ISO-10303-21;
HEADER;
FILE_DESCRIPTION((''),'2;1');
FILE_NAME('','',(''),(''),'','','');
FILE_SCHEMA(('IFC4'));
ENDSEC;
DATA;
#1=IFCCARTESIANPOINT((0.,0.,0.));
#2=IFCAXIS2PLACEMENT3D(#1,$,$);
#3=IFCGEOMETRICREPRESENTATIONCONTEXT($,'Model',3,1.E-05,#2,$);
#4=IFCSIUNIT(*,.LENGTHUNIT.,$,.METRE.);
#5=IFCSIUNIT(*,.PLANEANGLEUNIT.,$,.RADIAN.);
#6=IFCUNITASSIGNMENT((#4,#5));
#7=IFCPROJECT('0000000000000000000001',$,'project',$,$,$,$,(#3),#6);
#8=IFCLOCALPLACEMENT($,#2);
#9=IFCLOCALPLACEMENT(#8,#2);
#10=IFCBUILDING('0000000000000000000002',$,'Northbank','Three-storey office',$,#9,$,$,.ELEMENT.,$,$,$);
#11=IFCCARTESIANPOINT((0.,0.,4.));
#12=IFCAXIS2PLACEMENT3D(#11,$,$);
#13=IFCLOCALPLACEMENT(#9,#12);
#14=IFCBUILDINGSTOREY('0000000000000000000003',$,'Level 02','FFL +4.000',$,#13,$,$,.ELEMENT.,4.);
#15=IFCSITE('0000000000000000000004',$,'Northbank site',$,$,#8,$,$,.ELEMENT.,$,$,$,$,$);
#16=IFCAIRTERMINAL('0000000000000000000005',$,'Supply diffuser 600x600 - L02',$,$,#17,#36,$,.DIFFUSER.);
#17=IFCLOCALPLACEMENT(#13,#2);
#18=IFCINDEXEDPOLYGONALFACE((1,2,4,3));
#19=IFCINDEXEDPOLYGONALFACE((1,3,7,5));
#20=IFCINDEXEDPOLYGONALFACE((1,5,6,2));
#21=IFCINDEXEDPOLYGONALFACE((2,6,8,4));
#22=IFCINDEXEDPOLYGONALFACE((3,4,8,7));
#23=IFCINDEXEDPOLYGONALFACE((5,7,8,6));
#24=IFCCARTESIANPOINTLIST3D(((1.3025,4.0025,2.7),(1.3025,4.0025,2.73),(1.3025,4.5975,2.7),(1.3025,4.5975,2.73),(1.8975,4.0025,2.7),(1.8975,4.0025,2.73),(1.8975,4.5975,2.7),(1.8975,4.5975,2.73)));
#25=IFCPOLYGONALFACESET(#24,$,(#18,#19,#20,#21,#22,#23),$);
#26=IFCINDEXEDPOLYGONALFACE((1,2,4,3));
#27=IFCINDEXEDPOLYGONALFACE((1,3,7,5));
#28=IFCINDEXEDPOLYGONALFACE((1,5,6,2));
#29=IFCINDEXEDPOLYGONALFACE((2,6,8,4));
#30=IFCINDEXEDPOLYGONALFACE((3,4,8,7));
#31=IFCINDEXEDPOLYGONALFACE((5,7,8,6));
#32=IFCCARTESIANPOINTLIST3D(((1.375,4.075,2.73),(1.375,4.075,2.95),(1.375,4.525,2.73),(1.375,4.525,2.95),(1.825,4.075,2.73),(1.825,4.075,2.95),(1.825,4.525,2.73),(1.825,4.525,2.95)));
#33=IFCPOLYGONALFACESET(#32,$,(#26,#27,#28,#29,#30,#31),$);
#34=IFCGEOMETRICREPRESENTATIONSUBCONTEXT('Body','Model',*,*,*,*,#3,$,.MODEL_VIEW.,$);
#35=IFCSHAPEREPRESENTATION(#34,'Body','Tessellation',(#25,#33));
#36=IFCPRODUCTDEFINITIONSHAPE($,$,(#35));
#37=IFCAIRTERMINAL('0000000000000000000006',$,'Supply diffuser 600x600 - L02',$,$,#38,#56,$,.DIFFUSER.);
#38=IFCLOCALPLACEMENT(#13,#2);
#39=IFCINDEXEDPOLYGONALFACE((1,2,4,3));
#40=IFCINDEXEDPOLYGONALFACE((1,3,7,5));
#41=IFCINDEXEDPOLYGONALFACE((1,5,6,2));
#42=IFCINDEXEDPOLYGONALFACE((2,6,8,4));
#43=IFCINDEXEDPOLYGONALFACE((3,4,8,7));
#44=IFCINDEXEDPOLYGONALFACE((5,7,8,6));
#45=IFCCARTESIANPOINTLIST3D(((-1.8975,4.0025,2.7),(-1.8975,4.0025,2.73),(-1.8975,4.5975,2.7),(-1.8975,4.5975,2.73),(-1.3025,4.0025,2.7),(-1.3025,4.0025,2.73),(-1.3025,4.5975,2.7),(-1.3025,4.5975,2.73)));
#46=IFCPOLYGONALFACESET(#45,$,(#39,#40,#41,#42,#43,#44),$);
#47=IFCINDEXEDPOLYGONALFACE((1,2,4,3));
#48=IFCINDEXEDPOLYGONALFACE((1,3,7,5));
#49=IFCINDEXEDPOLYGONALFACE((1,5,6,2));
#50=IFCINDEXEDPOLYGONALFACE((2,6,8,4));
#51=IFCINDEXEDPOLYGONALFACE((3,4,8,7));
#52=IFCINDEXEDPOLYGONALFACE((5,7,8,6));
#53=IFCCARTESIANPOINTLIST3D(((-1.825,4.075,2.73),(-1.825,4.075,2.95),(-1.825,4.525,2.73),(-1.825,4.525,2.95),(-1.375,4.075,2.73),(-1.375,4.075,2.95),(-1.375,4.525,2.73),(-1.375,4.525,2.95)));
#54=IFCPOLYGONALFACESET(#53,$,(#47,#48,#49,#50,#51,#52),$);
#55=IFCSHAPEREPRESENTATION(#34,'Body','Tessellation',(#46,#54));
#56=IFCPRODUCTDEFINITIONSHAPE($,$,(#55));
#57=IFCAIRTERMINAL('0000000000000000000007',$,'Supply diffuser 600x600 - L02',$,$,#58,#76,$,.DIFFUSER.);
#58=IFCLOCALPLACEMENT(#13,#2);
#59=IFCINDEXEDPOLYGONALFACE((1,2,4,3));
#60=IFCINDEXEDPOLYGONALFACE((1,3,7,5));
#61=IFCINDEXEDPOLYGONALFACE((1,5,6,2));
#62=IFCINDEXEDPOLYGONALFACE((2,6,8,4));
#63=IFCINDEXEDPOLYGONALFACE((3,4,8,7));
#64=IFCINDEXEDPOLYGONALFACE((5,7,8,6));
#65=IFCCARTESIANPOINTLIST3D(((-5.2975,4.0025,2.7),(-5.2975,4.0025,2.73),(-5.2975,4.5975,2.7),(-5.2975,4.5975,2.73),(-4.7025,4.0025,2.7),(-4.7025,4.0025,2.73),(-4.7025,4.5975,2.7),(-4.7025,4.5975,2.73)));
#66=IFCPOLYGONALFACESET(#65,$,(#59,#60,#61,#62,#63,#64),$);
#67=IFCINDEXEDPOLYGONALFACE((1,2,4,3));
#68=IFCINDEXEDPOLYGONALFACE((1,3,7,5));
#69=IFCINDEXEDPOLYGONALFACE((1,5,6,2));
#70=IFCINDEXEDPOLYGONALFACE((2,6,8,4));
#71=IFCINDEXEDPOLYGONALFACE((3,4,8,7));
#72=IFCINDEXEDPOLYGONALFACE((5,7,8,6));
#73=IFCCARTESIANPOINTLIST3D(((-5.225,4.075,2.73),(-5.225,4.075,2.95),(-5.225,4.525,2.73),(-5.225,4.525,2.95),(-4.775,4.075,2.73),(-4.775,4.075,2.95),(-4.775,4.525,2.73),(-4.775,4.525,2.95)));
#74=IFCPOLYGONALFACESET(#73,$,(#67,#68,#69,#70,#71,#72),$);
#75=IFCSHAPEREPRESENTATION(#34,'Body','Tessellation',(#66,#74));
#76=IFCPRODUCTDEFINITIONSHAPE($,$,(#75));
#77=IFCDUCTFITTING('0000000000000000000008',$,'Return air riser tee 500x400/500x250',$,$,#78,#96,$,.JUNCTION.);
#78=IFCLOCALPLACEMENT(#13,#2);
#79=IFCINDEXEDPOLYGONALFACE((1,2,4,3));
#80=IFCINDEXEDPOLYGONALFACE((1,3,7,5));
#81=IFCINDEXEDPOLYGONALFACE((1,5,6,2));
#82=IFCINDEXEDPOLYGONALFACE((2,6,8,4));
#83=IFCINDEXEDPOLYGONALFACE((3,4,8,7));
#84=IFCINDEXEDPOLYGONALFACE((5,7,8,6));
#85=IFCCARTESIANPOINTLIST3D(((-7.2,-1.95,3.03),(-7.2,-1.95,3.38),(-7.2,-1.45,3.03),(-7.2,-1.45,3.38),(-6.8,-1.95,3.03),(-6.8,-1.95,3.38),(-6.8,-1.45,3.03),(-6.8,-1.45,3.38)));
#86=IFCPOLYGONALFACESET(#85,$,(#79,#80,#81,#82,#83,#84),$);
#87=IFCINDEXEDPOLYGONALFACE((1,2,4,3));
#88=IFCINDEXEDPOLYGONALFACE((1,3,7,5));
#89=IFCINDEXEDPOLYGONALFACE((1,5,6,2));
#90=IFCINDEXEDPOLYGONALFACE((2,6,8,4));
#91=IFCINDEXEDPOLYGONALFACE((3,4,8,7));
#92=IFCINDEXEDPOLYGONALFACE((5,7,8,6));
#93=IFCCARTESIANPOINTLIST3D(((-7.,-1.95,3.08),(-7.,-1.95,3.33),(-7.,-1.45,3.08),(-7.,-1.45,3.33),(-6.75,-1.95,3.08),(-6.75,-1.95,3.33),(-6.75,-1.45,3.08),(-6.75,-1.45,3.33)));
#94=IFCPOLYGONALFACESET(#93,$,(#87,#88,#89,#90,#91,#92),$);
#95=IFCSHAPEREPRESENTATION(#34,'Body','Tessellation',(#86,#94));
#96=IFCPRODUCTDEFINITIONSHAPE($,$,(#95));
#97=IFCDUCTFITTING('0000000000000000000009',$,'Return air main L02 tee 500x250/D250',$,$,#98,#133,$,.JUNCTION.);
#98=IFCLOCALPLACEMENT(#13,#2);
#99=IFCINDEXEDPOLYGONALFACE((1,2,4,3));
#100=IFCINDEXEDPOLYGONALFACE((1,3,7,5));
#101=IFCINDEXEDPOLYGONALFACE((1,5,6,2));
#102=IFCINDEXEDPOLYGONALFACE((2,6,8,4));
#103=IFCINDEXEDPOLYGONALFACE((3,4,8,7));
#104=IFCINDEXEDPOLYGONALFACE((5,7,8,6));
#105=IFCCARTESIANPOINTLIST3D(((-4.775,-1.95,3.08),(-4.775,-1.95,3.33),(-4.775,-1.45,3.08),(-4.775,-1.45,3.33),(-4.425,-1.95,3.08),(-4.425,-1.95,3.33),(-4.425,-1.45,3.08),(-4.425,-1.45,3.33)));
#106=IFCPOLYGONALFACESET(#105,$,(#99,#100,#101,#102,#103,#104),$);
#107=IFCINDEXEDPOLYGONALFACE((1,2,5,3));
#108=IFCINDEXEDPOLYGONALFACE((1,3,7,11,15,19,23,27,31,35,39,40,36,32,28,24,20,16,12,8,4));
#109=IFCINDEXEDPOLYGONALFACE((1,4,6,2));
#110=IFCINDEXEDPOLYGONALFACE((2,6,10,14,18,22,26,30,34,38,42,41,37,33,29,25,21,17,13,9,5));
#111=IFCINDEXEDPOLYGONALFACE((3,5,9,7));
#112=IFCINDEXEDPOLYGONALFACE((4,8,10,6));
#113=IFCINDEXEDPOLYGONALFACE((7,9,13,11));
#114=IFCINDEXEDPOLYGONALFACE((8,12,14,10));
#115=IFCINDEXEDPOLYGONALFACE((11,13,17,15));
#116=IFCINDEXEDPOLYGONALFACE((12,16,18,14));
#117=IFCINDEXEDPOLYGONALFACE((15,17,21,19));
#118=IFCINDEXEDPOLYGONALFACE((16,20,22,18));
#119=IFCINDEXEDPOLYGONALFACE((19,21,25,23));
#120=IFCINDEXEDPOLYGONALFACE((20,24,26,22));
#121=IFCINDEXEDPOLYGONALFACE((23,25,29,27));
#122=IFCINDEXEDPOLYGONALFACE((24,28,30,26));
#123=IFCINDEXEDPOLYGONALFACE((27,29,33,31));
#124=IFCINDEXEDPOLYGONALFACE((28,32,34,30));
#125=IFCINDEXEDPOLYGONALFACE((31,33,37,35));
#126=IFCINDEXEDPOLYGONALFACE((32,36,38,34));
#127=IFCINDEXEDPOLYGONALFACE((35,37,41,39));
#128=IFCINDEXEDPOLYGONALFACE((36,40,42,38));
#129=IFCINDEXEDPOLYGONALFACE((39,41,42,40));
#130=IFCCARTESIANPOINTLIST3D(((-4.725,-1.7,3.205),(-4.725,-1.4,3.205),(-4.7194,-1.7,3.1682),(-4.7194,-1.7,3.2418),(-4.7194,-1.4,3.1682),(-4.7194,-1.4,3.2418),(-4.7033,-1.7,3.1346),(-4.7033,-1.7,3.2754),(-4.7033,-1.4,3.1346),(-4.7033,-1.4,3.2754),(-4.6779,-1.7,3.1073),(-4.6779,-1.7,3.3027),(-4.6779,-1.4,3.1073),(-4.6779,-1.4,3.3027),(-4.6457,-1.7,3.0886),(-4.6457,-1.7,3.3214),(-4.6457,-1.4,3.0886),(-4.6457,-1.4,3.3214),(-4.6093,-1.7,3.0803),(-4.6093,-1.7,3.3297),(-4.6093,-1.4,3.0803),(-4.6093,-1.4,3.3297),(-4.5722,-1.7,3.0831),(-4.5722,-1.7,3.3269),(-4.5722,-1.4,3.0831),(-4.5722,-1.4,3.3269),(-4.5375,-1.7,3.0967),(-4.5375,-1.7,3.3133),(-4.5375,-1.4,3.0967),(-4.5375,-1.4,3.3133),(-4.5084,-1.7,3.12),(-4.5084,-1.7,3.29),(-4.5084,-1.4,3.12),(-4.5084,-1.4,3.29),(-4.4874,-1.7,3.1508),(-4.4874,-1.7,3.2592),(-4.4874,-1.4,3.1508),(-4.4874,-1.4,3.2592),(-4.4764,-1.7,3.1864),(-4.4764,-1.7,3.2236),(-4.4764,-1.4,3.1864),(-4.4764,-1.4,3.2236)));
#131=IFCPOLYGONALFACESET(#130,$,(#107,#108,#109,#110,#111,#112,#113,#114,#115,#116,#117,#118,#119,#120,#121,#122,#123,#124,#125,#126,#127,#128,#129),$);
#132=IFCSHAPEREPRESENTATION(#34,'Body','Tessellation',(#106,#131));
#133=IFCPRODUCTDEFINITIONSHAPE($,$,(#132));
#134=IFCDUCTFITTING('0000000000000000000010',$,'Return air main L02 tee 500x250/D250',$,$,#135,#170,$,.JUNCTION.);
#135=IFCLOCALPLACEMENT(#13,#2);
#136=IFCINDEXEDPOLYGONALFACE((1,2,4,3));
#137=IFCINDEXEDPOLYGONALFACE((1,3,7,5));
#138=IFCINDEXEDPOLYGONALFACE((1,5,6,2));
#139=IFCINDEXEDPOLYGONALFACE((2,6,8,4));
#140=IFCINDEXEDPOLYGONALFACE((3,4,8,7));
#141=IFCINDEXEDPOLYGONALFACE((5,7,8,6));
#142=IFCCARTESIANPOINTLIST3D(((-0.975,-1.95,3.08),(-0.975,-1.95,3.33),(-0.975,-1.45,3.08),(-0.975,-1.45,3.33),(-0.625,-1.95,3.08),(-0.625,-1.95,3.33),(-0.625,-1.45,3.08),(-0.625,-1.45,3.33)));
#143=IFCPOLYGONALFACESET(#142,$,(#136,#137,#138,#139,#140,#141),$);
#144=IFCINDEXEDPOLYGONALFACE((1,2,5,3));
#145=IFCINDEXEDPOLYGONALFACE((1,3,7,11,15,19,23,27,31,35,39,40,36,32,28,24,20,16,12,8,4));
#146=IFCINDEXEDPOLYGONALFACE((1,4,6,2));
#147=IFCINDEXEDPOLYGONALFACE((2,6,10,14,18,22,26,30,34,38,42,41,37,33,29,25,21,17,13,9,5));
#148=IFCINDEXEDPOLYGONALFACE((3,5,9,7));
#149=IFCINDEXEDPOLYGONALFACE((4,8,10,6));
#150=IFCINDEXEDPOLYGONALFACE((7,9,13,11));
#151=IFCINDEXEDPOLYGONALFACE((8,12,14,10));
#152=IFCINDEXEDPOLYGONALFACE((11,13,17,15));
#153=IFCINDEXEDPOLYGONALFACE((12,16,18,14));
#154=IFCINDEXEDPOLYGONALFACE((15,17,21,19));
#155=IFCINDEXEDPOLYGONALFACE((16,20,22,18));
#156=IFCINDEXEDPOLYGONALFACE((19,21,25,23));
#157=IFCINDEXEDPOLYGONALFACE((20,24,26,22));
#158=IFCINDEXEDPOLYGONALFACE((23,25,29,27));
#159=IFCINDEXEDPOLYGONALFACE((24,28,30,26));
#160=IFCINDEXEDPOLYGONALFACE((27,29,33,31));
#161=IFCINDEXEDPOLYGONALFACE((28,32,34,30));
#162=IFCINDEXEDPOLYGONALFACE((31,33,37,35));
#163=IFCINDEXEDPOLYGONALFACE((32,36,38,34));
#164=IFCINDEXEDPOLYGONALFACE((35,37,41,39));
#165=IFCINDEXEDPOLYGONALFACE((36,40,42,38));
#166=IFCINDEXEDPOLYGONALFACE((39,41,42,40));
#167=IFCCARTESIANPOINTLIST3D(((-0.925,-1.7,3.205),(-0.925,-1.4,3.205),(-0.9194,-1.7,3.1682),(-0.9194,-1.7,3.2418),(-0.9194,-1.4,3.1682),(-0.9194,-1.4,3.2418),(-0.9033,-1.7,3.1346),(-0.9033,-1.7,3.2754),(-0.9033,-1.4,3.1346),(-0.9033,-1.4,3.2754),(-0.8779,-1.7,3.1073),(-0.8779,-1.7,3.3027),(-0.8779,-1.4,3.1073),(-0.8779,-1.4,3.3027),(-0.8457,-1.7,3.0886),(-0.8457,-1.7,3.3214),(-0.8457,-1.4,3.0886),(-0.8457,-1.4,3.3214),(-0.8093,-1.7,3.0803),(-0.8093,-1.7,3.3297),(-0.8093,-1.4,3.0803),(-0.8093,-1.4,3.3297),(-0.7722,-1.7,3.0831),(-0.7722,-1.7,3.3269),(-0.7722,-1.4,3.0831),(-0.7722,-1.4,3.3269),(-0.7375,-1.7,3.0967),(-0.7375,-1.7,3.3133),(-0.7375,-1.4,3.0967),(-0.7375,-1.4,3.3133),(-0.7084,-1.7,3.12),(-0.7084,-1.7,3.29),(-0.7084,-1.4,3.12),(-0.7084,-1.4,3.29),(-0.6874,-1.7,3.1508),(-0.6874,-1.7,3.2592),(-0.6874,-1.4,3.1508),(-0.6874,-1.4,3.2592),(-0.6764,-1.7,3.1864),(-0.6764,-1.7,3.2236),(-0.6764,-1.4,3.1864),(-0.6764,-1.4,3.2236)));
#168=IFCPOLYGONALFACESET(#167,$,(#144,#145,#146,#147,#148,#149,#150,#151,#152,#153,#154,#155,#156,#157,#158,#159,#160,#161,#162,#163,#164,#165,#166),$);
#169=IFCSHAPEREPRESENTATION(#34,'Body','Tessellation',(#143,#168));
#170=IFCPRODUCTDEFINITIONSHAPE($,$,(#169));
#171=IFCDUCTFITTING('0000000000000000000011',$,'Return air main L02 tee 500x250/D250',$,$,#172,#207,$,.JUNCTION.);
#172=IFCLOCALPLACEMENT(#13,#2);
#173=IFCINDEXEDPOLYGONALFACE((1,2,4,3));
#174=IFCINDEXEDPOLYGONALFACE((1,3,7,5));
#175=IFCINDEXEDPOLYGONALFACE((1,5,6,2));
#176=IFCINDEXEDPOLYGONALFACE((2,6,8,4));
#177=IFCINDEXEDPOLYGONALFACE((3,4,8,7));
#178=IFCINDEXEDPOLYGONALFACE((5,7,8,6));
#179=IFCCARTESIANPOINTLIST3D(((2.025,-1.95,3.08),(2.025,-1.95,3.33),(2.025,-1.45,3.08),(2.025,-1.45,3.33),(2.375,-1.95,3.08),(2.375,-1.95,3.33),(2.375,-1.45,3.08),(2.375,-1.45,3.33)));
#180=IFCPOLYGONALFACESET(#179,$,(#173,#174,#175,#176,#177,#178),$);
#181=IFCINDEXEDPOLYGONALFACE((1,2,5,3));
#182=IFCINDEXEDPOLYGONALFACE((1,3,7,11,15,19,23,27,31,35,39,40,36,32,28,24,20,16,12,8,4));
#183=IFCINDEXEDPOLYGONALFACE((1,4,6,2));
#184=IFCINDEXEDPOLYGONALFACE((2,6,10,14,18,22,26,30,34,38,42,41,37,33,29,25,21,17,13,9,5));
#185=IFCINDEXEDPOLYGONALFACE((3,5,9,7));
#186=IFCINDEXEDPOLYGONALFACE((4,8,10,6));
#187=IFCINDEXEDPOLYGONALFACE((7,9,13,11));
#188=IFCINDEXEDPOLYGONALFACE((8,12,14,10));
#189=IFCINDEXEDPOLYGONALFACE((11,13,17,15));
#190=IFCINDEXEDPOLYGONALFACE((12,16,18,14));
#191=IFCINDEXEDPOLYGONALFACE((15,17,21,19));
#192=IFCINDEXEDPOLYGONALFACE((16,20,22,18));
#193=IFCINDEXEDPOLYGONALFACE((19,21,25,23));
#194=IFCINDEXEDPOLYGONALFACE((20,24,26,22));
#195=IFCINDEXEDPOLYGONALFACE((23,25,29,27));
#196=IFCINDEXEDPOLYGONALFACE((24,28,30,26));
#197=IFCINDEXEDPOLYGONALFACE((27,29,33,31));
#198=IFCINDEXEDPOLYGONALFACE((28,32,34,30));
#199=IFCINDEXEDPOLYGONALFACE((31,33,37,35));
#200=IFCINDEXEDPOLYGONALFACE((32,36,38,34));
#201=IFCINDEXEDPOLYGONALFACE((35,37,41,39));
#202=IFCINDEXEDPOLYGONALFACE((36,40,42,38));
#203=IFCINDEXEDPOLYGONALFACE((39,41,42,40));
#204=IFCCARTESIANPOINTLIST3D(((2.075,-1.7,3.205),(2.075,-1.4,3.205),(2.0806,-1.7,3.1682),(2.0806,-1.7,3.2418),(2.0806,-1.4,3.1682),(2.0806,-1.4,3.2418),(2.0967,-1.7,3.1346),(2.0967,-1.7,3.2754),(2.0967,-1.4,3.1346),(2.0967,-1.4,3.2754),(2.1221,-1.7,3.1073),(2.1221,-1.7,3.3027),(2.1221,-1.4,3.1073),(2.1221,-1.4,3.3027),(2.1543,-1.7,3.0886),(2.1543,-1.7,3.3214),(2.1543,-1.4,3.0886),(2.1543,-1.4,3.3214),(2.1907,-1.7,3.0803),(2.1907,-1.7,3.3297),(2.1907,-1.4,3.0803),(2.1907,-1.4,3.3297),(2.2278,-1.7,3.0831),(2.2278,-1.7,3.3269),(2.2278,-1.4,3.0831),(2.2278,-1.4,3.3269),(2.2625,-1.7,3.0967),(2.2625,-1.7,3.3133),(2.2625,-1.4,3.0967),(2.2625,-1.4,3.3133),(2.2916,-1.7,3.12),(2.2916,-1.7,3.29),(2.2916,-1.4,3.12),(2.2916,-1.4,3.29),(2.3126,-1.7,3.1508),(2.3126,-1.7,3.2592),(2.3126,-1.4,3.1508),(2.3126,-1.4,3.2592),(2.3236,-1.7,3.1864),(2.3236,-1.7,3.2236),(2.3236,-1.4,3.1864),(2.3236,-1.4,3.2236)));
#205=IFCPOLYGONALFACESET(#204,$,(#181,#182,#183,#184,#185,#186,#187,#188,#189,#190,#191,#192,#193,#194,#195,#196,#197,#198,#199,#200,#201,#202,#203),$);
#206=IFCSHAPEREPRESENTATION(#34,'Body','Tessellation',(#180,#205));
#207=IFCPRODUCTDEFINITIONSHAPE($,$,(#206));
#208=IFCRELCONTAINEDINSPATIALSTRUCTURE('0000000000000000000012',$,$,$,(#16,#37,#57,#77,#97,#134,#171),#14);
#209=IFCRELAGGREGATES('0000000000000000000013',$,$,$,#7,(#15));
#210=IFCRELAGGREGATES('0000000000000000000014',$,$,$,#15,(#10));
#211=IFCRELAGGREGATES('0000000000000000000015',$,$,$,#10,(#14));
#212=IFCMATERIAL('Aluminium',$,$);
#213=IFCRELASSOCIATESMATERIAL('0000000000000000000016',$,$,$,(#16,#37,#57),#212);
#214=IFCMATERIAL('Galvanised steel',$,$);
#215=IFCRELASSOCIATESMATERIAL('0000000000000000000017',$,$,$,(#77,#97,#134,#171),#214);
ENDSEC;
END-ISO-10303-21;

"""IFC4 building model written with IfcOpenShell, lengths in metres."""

from ifc_helpers import new_model, si_unit, frame, origin, place, context, subcontext, project, spatial, rectangle, circle, extrude, material, element, save


model = new_model("IFC4")

# Units and contexts
model_context = context("Model", 3, precision=1e-05, world=origin())
body_context = subcontext(model_context, "Body", "Model", "MODEL_VIEW")
ifc_project = project(units=[si_unit("LENGTHUNIT", "METRE"), si_unit("PLANEANGLEUNIT", "RADIAN")], contexts=[model_context])

# Site, building, storey
site_placement = place(None, origin())
site = spatial("IfcSite", under=ifc_project, at=site_placement, Name="Northbank site", CompositionType="ELEMENT")
building_placement = place(site_placement, origin())
building = spatial("IfcBuilding", under=site, at=building_placement, Name="Northbank", Description="Three-storey office", CompositionType="ELEMENT")
storey_placement = place(building_placement, frame((0.0, 0.0, 4.0)))
storey = spatial("IfcBuildingStorey", under=building, at=storey_placement, Name="Level 02", Description="FFL +4.000", CompositionType="ELEMENT", Elevation=4.0)

# Shared definitions
ifc_material_1 = material(Name="Galvanised steel")

# Air terminal
ifc_material_2 = material(Name="Aluminium")
air_terminal_1_placement = place(storey_placement, frame((0.0, 0.0, -4.0)))
element("IfcAirTerminal", 1, at=air_terminal_1_placement, inside=storey, material=ifc_material_2, Name="Supply diffuser 600x600 - L02", PredefinedType="DIFFUSER", context=body_context, shape_type="SweptSolid", body=[
    extrude(rectangle(XDim=0.595, YDim=0.595), frame((1.6, 4.3, 6.7)), (0.0, 0.0, 1.0), 0.03),
    extrude(rectangle(XDim=0.45, YDim=0.45), frame((1.6, 4.3, 6.73)), (0.0, 0.0, 1.0), 0.22),
])

# Air terminal
air_terminal_2_placement = place(storey_placement, frame((0.0, 0.0, -4.0)))
element("IfcAirTerminal", 2, at=air_terminal_2_placement, inside=storey, material=ifc_material_2, Name="Supply diffuser 600x600 - L02", PredefinedType="DIFFUSER", context=body_context, shape_type="SweptSolid", body=[
    extrude(rectangle(XDim=0.595, YDim=0.595), frame((-1.6, 4.3, 6.7)), (0.0, 0.0, 1.0), 0.03),
    extrude(rectangle(XDim=0.45, YDim=0.45), frame((-1.6, 4.3, 6.73)), (0.0, 0.0, 1.0), 0.22),
])

# Air terminal
air_terminal_3_placement = place(storey_placement, frame((0.0, 0.0, -4.0)))
element("IfcAirTerminal", 3, at=air_terminal_3_placement, inside=storey, material=ifc_material_2, Name="Supply diffuser 600x600 - L02", PredefinedType="DIFFUSER", context=body_context, shape_type="SweptSolid", body=[
    extrude(rectangle(XDim=0.595, YDim=0.595), frame((-5.0, 4.3, 6.7)), (0.0, 0.0, 1.0), 0.03),
    extrude(rectangle(XDim=0.45, YDim=0.45), frame((-5.0, 4.3, 6.73)), (0.0, 0.0, 1.0), 0.22),
])

# Duct fitting
duct_fitting_1_placement = place(storey_placement, frame((0.0, 0.0, -4.0)))
element("IfcDuctFitting", 4, at=duct_fitting_1_placement, inside=storey, material=ifc_material_1, Name="Return air riser tee 500x400/500x250", PredefinedType="JUNCTION", context=body_context, shape_type="SweptSolid", body=[
    extrude(rectangle(XDim=0.5, YDim=0.4), frame((-7.0, -1.7, 7.38), z_axis=(0.0, 0.0, -1.0), x_axis=(0.0, -1.0, 0.0)), (0.0, 0.0, 1.0), 0.35),
    extrude(rectangle(XDim=0.5, YDim=0.25), frame((-7.0, -1.7, 7.205), z_axis=(1.0, 0.0, 0.0), x_axis=(0.0, 1.0, 0.0)), (0.0, 0.0, 1.0), 0.25),
])

# Duct fitting
duct_fitting_2_placement = place(storey_placement, frame((0.0, 0.0, -4.0)))
element("IfcDuctFitting", 5, at=duct_fitting_2_placement, inside=storey, material=ifc_material_1, Name="Return air main L02 tee 500x250/D250", PredefinedType="JUNCTION", context=body_context, shape_type="SweptSolid", body=[
    extrude(rectangle(XDim=0.5, YDim=0.25), frame((-4.775, -1.7, 7.205), z_axis=(1.0, 0.0, 0.0), x_axis=(0.0, 1.0, 0.0)), (0.0, 0.0, 1.0), 0.35),
    extrude(circle(Radius=0.125), frame((-4.6, -1.7, 7.205), z_axis=(0.0, 1.0, 0.0), x_axis=(-1.0, 0.0, 0.0)), (0.0, 0.0, 1.0), 0.3),
])

# Duct fitting
duct_fitting_3_placement = place(storey_placement, frame((0.0, 0.0, -4.0)))
element("IfcDuctFitting", 6, at=duct_fitting_3_placement, inside=storey, material=ifc_material_1, Name="Return air main L02 tee 500x250/D250", PredefinedType="JUNCTION", context=body_context, shape_type="SweptSolid", body=[
    extrude(rectangle(XDim=0.5, YDim=0.25), frame((-0.975, -1.7, 7.205), z_axis=(1.0, 0.0, 0.0), x_axis=(0.0, 1.0, 0.0)), (0.0, 0.0, 1.0), 0.35),
    extrude(circle(Radius=0.125), frame((-0.8, -1.7, 7.205), z_axis=(0.0, 1.0, 0.0), x_axis=(-1.0, 0.0, 0.0)), (0.0, 0.0, 1.0), 0.3),
])

# Duct fitting
duct_fitting_4_placement = place(storey_placement, frame((0.0, 0.0, -4.0)))
element("IfcDuctFitting", 7, at=duct_fitting_4_placement, inside=storey, material=ifc_material_1, Name="Return air main L02 tee 500x250/D250", PredefinedType="JUNCTION", context=body_context, shape_type="SweptSolid", body=[
    extrude(rectangle(XDim=0.5, YDim=0.25), frame((2.025, -1.7, 7.205), z_axis=(1.0, 0.0, 0.0), x_axis=(0.0, 1.0, 0.0)), (0.0, 0.0, 1.0), 0.35),
    extrude(circle(Radius=0.125), frame((2.2, -1.7, 7.205), z_axis=(0.0, 1.0, 0.0), x_axis=(-1.0, 0.0, 0.0)), (0.0, 0.0, 1.0), 0.3),
])

save(model, "model.ifc")
